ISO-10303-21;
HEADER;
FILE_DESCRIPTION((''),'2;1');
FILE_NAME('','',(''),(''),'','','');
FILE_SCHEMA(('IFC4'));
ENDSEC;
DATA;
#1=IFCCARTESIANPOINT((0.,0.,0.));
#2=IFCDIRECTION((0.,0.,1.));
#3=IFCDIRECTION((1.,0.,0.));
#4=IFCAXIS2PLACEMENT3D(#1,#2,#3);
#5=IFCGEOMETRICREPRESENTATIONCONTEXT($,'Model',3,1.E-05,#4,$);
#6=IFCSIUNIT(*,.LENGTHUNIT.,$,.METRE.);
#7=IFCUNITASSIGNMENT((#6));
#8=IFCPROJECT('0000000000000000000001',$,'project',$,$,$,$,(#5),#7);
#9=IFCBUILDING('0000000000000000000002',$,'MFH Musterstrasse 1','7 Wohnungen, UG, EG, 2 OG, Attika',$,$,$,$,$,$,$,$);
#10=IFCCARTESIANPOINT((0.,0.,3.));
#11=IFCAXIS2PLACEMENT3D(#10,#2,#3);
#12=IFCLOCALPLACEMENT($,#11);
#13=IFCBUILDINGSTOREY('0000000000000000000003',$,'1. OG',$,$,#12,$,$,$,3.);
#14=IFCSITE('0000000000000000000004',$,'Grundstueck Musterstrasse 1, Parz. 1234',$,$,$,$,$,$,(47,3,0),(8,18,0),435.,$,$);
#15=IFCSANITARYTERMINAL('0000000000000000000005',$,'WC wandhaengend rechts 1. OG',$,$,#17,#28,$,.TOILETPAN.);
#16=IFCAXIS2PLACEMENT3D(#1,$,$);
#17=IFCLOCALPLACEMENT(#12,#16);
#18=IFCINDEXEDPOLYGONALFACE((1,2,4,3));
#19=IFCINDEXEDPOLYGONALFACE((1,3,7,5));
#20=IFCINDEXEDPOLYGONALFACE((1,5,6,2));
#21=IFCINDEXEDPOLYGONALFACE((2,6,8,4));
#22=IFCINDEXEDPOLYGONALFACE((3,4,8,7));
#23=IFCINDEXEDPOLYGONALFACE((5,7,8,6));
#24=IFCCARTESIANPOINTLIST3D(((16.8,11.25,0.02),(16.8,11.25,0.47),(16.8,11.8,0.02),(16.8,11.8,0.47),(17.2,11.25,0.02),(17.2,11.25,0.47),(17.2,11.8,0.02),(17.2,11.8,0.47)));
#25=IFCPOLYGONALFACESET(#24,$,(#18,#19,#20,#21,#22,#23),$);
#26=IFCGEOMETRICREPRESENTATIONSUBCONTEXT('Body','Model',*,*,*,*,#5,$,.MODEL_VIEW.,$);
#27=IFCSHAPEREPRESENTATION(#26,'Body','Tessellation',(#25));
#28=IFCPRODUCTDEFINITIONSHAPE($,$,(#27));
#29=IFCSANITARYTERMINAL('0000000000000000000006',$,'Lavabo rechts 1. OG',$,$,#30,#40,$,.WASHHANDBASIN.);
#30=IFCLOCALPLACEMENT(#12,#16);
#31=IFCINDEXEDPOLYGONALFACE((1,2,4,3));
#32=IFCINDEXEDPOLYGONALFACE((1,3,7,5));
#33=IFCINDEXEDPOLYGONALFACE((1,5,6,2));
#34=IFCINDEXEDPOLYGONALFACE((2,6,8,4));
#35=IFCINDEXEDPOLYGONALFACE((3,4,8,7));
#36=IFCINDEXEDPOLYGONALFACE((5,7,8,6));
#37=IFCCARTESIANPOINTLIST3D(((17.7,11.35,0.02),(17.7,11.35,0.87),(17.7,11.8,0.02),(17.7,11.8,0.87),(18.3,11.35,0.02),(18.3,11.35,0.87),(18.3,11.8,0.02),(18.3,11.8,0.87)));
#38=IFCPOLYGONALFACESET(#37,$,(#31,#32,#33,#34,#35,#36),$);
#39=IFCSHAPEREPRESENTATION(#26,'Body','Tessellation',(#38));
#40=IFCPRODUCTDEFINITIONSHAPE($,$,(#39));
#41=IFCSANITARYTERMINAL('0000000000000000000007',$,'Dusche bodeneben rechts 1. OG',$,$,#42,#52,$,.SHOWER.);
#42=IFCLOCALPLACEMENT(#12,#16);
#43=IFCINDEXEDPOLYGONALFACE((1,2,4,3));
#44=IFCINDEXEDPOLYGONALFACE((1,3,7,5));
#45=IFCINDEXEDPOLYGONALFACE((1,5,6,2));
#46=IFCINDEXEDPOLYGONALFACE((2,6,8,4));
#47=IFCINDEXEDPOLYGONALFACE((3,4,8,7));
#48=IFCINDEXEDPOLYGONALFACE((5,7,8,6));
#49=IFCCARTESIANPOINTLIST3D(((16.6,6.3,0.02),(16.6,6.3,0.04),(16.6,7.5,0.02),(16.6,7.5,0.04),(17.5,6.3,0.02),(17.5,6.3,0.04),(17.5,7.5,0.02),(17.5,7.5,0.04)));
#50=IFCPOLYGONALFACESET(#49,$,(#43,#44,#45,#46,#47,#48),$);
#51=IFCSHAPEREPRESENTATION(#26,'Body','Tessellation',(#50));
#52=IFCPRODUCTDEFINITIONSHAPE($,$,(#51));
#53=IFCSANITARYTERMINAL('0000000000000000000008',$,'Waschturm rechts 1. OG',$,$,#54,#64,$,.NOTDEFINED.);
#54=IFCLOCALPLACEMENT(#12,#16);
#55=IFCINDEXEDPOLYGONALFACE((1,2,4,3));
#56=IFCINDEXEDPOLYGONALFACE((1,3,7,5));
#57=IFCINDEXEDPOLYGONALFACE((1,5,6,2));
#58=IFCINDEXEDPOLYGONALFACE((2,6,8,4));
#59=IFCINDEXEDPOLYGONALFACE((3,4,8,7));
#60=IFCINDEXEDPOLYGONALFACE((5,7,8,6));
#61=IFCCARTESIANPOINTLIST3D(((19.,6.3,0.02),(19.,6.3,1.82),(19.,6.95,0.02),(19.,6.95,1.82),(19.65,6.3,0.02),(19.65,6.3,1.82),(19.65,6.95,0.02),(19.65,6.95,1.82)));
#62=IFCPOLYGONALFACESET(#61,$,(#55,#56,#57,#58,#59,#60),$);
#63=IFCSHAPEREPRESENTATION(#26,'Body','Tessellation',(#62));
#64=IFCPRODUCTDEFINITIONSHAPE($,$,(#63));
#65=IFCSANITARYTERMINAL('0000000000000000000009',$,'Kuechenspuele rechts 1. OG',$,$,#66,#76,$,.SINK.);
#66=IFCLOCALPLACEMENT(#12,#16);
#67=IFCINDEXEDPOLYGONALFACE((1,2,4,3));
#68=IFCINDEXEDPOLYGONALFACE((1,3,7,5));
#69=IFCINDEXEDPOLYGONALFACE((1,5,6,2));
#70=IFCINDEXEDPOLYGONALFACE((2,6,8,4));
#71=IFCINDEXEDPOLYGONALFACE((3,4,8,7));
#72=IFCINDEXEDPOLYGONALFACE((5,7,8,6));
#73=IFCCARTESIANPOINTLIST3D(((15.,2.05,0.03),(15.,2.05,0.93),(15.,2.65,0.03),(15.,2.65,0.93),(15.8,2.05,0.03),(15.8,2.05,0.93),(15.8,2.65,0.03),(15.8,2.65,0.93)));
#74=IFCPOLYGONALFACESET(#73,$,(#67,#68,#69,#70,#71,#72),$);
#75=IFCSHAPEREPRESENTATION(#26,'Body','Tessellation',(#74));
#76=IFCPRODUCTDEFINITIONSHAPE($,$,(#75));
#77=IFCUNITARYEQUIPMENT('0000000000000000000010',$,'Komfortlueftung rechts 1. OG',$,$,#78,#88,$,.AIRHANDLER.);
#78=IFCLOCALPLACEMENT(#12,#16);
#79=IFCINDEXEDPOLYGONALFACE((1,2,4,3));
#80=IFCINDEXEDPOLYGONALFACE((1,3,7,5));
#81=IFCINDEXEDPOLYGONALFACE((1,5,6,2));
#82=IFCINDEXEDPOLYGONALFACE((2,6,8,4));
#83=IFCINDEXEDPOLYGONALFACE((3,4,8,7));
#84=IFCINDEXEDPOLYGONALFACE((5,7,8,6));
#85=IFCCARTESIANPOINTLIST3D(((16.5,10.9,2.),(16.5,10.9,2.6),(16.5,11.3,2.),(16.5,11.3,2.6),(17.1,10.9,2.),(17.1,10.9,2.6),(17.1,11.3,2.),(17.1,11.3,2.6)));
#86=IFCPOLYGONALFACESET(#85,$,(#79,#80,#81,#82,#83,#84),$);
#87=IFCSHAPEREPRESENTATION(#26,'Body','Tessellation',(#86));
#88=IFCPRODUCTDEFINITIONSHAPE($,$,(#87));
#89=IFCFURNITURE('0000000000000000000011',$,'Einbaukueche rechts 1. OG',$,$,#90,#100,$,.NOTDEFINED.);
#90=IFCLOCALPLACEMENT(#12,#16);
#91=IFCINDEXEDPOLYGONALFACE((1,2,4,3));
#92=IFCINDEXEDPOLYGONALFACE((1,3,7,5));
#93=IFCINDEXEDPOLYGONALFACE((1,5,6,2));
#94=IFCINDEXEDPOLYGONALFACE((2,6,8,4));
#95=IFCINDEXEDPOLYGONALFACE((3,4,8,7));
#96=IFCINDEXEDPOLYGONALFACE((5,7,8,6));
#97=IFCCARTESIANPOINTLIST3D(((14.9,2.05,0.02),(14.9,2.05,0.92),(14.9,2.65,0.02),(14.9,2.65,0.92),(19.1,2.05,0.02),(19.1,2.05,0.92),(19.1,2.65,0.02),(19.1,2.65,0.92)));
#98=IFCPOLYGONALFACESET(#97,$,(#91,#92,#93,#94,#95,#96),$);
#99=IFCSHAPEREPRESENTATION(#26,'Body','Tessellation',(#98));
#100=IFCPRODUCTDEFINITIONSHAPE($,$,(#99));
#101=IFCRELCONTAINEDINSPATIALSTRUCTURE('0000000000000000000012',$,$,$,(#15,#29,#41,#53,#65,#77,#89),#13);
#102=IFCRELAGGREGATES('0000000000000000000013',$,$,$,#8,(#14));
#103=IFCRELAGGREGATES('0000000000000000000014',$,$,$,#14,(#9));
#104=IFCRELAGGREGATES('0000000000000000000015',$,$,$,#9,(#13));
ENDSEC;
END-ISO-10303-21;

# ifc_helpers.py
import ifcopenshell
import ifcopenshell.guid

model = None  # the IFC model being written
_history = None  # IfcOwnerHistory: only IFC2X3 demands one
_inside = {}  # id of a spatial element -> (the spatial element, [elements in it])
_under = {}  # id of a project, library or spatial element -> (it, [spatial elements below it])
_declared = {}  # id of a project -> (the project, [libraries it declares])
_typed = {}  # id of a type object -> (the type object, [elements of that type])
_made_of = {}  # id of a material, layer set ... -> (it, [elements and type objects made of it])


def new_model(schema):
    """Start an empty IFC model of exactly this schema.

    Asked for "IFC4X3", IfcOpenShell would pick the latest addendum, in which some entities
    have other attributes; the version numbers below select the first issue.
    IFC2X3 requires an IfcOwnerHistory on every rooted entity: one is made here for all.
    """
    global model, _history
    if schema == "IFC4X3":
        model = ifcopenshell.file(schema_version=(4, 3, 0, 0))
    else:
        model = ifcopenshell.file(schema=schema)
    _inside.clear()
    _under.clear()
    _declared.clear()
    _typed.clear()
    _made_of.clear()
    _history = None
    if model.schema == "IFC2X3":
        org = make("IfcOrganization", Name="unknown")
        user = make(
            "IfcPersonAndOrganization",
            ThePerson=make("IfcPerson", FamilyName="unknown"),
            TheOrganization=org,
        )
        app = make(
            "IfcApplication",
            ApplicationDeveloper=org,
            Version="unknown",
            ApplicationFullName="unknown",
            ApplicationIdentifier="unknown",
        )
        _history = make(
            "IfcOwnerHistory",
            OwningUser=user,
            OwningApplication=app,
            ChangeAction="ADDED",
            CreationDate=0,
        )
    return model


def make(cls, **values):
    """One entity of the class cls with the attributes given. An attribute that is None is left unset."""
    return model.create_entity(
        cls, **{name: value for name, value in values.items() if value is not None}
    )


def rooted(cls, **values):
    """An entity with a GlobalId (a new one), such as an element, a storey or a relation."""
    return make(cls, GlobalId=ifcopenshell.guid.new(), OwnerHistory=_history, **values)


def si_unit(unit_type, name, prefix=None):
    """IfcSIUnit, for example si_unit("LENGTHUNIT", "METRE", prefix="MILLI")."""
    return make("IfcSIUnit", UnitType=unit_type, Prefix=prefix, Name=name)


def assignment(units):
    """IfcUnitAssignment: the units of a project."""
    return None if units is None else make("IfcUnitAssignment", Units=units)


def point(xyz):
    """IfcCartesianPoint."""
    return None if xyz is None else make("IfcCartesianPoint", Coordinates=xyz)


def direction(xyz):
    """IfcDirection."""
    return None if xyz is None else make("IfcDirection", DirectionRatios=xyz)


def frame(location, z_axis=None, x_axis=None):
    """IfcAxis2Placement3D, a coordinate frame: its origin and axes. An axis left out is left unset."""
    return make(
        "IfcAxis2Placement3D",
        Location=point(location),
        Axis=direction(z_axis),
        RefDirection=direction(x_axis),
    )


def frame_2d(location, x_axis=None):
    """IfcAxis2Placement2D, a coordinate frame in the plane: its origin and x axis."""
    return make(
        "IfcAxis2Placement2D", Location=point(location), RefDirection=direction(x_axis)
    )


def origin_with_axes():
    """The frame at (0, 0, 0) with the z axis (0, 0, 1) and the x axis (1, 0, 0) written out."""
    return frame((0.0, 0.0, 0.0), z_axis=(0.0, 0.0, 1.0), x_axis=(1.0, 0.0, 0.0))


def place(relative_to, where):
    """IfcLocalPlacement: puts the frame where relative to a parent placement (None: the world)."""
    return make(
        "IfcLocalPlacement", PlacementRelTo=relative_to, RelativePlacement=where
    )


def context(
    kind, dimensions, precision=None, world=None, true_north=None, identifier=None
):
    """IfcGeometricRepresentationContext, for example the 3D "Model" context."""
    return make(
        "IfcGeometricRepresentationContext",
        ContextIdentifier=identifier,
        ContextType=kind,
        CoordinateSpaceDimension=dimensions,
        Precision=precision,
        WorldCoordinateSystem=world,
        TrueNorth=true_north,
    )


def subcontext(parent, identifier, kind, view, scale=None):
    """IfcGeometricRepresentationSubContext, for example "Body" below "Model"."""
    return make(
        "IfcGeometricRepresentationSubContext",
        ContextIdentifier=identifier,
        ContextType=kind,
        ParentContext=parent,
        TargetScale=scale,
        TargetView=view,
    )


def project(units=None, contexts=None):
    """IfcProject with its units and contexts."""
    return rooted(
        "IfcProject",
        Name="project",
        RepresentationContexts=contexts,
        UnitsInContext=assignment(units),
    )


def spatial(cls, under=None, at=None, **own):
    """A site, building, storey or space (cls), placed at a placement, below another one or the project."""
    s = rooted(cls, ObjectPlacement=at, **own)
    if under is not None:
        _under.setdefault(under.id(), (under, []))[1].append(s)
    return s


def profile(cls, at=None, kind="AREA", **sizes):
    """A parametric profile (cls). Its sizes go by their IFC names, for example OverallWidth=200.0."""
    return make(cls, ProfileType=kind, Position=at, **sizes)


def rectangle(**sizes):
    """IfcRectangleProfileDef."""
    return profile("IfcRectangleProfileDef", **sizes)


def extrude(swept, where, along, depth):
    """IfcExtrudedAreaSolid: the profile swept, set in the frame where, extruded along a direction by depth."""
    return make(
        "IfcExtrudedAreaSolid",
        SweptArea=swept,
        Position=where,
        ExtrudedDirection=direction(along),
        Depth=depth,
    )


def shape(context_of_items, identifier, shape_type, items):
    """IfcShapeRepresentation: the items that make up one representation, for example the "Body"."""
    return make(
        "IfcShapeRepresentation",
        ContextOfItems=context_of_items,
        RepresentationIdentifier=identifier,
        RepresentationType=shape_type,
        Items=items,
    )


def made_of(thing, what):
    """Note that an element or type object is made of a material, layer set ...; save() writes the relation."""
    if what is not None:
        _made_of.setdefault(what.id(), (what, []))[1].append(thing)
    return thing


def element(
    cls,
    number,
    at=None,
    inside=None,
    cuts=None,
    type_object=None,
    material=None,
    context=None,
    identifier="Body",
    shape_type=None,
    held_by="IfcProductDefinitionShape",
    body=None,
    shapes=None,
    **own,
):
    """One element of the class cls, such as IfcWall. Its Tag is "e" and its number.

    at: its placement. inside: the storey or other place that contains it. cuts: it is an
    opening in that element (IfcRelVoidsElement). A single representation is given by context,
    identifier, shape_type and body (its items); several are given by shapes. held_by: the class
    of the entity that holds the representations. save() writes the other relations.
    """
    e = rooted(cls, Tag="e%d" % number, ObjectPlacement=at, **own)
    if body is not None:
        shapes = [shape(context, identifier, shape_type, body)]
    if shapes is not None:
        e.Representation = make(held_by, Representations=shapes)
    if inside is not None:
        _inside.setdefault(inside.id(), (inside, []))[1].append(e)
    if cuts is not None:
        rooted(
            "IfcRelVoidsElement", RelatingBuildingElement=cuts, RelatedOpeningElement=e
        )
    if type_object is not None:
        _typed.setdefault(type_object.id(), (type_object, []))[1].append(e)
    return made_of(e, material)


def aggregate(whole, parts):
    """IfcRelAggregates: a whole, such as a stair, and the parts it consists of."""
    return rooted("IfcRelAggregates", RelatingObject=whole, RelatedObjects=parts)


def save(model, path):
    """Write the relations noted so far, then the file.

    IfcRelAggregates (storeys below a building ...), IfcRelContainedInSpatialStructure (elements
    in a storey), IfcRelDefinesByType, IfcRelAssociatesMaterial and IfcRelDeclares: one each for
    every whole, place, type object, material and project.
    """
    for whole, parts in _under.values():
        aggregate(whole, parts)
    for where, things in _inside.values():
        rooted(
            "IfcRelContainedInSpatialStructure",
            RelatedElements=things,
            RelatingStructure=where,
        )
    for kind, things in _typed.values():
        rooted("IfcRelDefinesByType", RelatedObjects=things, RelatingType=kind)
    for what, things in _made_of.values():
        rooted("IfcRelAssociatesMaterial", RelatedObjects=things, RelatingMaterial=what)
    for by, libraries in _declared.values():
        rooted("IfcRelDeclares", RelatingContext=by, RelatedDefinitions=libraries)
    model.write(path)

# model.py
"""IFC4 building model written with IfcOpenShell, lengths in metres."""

from ifc_helpers import new_model, si_unit, frame, frame_2d, origin_with_axes, place, context, subcontext, project, spatial, rectangle, extrude, element, save


model = new_model("IFC4")

# Units and contexts
model_context = context("Model", 3, precision=1e-05, world=origin_with_axes())
body_context = subcontext(model_context, "Body", "Model", "MODEL_VIEW")
ifc_project = project(units=[si_unit("LENGTHUNIT", "METRE")], contexts=[model_context])

# Site, building, storey
site = spatial("IfcSite", under=ifc_project, Name="Grundstueck Musterstrasse 1, Parz. 1234", RefLatitude=(47, 3, 0), RefLongitude=(8, 18, 0), RefElevation=435.0)
building = spatial("IfcBuilding", under=site, Name="MFH Musterstrasse 1", Description="7 Wohnungen, UG, EG, 2 OG, Attika")
storey_placement = place(None, frame((0.0, 0.0, 3.0), z_axis=(0.0, 0.0, 1.0), x_axis=(1.0, 0.0, 0.0)))
storey = spatial("IfcBuildingStorey", under=building, at=storey_placement, Name="1. OG", Elevation=3.0)

# Sanitary terminals
sanitary_terminal_1_placement = place(storey_placement, frame((16.8, 11.25, 0.02), z_axis=(0.0, 0.0, 1.0), x_axis=(1.0, 0.0, 0.0)))
element("IfcSanitaryTerminal", 1, at=sanitary_terminal_1_placement, inside=storey, Name="WC wandhaengend rechts 1. OG", PredefinedType="TOILETPAN", context=body_context, shape_type="SweptSolid", body=[
    extrude(rectangle(XDim=0.4, YDim=0.55, at=frame_2d((0.2, 0.275))), origin_with_axes(), (0.0, 0.0, 1.0), 0.45),
])
sanitary_terminal_2_placement = place(storey_placement, frame((17.7, 11.35, 0.02), z_axis=(0.0, 0.0, 1.0), x_axis=(1.0, 0.0, 0.0)))
element("IfcSanitaryTerminal", 2, at=sanitary_terminal_2_placement, inside=storey, Name="Lavabo rechts 1. OG", PredefinedType="WASHHANDBASIN", context=body_context, shape_type="SweptSolid", body=[
    extrude(rectangle(XDim=0.6, YDim=0.45, at=frame_2d((0.3, 0.225))), origin_with_axes(), (0.0, 0.0, 1.0), 0.85),
])
sanitary_terminal_3_placement = place(storey_placement, frame((16.6, 6.3, 0.02), z_axis=(0.0, 0.0, 1.0), x_axis=(1.0, 0.0, 0.0)))
element("IfcSanitaryTerminal", 3, at=sanitary_terminal_3_placement, inside=storey, Name="Dusche bodeneben rechts 1. OG", PredefinedType="SHOWER", context=body_context, shape_type="SweptSolid", body=[
    extrude(rectangle(XDim=0.9, YDim=1.2, at=frame_2d((0.45, 0.6))), origin_with_axes(), (0.0, 0.0, 1.0), 0.02),
])
sanitary_terminal_4_placement = place(storey_placement, frame((19.0, 6.3, 0.02), z_axis=(0.0, 0.0, 1.0), x_axis=(1.0, 0.0, 0.0)))
element("IfcSanitaryTerminal", 4, at=sanitary_terminal_4_placement, inside=storey, Name="Waschturm rechts 1. OG", PredefinedType="NOTDEFINED", context=body_context, shape_type="SweptSolid", body=[
    extrude(rectangle(XDim=0.65, YDim=0.65, at=frame_2d((0.325, 0.325))), origin_with_axes(), (0.0, 0.0, 1.0), 1.8),
])
sanitary_terminal_5_placement = place(storey_placement, frame((15.0, 2.05, 0.03), z_axis=(0.0, 0.0, 1.0), x_axis=(1.0, 0.0, 0.0)))
element("IfcSanitaryTerminal", 5, at=sanitary_terminal_5_placement, inside=storey, Name="Kuechenspuele rechts 1. OG", PredefinedType="SINK", context=body_context, shape_type="SweptSolid", body=[
    extrude(rectangle(XDim=0.8, YDim=0.6, at=frame_2d((0.4, 0.3))), origin_with_axes(), (0.0, 0.0, 1.0), 0.9),
])

# Unitary equipment
unitary_equipment_placement = place(storey_placement, frame((16.5, 10.9, 2.0), z_axis=(0.0, 0.0, 1.0), x_axis=(1.0, 0.0, 0.0)))
element("IfcUnitaryEquipment", 6, at=unitary_equipment_placement, inside=storey, Name="Komfortlueftung rechts 1. OG", PredefinedType="AIRHANDLER", context=body_context, shape_type="SweptSolid", body=[
    extrude(rectangle(XDim=0.6, YDim=0.4, at=frame_2d((0.3, 0.2))), origin_with_axes(), (0.0, 0.0, 1.0), 0.6),
])

# Furniture
furniture_placement = place(storey_placement, frame((14.9, 2.05, 0.02), z_axis=(0.0, 0.0, 1.0), x_axis=(1.0, 0.0, 0.0)))
element("IfcFurniture", 7, at=furniture_placement, inside=storey, Name="Einbaukueche rechts 1. OG", PredefinedType="NOTDEFINED", context=body_context, shape_type="SweptSolid", body=[
    extrude(rectangle(XDim=4.2, YDim=0.6, at=frame_2d((2.1, 0.3))), origin_with_axes(), (0.0, 0.0, 1.0), 0.9),
])

save(model, "model.ifc")
